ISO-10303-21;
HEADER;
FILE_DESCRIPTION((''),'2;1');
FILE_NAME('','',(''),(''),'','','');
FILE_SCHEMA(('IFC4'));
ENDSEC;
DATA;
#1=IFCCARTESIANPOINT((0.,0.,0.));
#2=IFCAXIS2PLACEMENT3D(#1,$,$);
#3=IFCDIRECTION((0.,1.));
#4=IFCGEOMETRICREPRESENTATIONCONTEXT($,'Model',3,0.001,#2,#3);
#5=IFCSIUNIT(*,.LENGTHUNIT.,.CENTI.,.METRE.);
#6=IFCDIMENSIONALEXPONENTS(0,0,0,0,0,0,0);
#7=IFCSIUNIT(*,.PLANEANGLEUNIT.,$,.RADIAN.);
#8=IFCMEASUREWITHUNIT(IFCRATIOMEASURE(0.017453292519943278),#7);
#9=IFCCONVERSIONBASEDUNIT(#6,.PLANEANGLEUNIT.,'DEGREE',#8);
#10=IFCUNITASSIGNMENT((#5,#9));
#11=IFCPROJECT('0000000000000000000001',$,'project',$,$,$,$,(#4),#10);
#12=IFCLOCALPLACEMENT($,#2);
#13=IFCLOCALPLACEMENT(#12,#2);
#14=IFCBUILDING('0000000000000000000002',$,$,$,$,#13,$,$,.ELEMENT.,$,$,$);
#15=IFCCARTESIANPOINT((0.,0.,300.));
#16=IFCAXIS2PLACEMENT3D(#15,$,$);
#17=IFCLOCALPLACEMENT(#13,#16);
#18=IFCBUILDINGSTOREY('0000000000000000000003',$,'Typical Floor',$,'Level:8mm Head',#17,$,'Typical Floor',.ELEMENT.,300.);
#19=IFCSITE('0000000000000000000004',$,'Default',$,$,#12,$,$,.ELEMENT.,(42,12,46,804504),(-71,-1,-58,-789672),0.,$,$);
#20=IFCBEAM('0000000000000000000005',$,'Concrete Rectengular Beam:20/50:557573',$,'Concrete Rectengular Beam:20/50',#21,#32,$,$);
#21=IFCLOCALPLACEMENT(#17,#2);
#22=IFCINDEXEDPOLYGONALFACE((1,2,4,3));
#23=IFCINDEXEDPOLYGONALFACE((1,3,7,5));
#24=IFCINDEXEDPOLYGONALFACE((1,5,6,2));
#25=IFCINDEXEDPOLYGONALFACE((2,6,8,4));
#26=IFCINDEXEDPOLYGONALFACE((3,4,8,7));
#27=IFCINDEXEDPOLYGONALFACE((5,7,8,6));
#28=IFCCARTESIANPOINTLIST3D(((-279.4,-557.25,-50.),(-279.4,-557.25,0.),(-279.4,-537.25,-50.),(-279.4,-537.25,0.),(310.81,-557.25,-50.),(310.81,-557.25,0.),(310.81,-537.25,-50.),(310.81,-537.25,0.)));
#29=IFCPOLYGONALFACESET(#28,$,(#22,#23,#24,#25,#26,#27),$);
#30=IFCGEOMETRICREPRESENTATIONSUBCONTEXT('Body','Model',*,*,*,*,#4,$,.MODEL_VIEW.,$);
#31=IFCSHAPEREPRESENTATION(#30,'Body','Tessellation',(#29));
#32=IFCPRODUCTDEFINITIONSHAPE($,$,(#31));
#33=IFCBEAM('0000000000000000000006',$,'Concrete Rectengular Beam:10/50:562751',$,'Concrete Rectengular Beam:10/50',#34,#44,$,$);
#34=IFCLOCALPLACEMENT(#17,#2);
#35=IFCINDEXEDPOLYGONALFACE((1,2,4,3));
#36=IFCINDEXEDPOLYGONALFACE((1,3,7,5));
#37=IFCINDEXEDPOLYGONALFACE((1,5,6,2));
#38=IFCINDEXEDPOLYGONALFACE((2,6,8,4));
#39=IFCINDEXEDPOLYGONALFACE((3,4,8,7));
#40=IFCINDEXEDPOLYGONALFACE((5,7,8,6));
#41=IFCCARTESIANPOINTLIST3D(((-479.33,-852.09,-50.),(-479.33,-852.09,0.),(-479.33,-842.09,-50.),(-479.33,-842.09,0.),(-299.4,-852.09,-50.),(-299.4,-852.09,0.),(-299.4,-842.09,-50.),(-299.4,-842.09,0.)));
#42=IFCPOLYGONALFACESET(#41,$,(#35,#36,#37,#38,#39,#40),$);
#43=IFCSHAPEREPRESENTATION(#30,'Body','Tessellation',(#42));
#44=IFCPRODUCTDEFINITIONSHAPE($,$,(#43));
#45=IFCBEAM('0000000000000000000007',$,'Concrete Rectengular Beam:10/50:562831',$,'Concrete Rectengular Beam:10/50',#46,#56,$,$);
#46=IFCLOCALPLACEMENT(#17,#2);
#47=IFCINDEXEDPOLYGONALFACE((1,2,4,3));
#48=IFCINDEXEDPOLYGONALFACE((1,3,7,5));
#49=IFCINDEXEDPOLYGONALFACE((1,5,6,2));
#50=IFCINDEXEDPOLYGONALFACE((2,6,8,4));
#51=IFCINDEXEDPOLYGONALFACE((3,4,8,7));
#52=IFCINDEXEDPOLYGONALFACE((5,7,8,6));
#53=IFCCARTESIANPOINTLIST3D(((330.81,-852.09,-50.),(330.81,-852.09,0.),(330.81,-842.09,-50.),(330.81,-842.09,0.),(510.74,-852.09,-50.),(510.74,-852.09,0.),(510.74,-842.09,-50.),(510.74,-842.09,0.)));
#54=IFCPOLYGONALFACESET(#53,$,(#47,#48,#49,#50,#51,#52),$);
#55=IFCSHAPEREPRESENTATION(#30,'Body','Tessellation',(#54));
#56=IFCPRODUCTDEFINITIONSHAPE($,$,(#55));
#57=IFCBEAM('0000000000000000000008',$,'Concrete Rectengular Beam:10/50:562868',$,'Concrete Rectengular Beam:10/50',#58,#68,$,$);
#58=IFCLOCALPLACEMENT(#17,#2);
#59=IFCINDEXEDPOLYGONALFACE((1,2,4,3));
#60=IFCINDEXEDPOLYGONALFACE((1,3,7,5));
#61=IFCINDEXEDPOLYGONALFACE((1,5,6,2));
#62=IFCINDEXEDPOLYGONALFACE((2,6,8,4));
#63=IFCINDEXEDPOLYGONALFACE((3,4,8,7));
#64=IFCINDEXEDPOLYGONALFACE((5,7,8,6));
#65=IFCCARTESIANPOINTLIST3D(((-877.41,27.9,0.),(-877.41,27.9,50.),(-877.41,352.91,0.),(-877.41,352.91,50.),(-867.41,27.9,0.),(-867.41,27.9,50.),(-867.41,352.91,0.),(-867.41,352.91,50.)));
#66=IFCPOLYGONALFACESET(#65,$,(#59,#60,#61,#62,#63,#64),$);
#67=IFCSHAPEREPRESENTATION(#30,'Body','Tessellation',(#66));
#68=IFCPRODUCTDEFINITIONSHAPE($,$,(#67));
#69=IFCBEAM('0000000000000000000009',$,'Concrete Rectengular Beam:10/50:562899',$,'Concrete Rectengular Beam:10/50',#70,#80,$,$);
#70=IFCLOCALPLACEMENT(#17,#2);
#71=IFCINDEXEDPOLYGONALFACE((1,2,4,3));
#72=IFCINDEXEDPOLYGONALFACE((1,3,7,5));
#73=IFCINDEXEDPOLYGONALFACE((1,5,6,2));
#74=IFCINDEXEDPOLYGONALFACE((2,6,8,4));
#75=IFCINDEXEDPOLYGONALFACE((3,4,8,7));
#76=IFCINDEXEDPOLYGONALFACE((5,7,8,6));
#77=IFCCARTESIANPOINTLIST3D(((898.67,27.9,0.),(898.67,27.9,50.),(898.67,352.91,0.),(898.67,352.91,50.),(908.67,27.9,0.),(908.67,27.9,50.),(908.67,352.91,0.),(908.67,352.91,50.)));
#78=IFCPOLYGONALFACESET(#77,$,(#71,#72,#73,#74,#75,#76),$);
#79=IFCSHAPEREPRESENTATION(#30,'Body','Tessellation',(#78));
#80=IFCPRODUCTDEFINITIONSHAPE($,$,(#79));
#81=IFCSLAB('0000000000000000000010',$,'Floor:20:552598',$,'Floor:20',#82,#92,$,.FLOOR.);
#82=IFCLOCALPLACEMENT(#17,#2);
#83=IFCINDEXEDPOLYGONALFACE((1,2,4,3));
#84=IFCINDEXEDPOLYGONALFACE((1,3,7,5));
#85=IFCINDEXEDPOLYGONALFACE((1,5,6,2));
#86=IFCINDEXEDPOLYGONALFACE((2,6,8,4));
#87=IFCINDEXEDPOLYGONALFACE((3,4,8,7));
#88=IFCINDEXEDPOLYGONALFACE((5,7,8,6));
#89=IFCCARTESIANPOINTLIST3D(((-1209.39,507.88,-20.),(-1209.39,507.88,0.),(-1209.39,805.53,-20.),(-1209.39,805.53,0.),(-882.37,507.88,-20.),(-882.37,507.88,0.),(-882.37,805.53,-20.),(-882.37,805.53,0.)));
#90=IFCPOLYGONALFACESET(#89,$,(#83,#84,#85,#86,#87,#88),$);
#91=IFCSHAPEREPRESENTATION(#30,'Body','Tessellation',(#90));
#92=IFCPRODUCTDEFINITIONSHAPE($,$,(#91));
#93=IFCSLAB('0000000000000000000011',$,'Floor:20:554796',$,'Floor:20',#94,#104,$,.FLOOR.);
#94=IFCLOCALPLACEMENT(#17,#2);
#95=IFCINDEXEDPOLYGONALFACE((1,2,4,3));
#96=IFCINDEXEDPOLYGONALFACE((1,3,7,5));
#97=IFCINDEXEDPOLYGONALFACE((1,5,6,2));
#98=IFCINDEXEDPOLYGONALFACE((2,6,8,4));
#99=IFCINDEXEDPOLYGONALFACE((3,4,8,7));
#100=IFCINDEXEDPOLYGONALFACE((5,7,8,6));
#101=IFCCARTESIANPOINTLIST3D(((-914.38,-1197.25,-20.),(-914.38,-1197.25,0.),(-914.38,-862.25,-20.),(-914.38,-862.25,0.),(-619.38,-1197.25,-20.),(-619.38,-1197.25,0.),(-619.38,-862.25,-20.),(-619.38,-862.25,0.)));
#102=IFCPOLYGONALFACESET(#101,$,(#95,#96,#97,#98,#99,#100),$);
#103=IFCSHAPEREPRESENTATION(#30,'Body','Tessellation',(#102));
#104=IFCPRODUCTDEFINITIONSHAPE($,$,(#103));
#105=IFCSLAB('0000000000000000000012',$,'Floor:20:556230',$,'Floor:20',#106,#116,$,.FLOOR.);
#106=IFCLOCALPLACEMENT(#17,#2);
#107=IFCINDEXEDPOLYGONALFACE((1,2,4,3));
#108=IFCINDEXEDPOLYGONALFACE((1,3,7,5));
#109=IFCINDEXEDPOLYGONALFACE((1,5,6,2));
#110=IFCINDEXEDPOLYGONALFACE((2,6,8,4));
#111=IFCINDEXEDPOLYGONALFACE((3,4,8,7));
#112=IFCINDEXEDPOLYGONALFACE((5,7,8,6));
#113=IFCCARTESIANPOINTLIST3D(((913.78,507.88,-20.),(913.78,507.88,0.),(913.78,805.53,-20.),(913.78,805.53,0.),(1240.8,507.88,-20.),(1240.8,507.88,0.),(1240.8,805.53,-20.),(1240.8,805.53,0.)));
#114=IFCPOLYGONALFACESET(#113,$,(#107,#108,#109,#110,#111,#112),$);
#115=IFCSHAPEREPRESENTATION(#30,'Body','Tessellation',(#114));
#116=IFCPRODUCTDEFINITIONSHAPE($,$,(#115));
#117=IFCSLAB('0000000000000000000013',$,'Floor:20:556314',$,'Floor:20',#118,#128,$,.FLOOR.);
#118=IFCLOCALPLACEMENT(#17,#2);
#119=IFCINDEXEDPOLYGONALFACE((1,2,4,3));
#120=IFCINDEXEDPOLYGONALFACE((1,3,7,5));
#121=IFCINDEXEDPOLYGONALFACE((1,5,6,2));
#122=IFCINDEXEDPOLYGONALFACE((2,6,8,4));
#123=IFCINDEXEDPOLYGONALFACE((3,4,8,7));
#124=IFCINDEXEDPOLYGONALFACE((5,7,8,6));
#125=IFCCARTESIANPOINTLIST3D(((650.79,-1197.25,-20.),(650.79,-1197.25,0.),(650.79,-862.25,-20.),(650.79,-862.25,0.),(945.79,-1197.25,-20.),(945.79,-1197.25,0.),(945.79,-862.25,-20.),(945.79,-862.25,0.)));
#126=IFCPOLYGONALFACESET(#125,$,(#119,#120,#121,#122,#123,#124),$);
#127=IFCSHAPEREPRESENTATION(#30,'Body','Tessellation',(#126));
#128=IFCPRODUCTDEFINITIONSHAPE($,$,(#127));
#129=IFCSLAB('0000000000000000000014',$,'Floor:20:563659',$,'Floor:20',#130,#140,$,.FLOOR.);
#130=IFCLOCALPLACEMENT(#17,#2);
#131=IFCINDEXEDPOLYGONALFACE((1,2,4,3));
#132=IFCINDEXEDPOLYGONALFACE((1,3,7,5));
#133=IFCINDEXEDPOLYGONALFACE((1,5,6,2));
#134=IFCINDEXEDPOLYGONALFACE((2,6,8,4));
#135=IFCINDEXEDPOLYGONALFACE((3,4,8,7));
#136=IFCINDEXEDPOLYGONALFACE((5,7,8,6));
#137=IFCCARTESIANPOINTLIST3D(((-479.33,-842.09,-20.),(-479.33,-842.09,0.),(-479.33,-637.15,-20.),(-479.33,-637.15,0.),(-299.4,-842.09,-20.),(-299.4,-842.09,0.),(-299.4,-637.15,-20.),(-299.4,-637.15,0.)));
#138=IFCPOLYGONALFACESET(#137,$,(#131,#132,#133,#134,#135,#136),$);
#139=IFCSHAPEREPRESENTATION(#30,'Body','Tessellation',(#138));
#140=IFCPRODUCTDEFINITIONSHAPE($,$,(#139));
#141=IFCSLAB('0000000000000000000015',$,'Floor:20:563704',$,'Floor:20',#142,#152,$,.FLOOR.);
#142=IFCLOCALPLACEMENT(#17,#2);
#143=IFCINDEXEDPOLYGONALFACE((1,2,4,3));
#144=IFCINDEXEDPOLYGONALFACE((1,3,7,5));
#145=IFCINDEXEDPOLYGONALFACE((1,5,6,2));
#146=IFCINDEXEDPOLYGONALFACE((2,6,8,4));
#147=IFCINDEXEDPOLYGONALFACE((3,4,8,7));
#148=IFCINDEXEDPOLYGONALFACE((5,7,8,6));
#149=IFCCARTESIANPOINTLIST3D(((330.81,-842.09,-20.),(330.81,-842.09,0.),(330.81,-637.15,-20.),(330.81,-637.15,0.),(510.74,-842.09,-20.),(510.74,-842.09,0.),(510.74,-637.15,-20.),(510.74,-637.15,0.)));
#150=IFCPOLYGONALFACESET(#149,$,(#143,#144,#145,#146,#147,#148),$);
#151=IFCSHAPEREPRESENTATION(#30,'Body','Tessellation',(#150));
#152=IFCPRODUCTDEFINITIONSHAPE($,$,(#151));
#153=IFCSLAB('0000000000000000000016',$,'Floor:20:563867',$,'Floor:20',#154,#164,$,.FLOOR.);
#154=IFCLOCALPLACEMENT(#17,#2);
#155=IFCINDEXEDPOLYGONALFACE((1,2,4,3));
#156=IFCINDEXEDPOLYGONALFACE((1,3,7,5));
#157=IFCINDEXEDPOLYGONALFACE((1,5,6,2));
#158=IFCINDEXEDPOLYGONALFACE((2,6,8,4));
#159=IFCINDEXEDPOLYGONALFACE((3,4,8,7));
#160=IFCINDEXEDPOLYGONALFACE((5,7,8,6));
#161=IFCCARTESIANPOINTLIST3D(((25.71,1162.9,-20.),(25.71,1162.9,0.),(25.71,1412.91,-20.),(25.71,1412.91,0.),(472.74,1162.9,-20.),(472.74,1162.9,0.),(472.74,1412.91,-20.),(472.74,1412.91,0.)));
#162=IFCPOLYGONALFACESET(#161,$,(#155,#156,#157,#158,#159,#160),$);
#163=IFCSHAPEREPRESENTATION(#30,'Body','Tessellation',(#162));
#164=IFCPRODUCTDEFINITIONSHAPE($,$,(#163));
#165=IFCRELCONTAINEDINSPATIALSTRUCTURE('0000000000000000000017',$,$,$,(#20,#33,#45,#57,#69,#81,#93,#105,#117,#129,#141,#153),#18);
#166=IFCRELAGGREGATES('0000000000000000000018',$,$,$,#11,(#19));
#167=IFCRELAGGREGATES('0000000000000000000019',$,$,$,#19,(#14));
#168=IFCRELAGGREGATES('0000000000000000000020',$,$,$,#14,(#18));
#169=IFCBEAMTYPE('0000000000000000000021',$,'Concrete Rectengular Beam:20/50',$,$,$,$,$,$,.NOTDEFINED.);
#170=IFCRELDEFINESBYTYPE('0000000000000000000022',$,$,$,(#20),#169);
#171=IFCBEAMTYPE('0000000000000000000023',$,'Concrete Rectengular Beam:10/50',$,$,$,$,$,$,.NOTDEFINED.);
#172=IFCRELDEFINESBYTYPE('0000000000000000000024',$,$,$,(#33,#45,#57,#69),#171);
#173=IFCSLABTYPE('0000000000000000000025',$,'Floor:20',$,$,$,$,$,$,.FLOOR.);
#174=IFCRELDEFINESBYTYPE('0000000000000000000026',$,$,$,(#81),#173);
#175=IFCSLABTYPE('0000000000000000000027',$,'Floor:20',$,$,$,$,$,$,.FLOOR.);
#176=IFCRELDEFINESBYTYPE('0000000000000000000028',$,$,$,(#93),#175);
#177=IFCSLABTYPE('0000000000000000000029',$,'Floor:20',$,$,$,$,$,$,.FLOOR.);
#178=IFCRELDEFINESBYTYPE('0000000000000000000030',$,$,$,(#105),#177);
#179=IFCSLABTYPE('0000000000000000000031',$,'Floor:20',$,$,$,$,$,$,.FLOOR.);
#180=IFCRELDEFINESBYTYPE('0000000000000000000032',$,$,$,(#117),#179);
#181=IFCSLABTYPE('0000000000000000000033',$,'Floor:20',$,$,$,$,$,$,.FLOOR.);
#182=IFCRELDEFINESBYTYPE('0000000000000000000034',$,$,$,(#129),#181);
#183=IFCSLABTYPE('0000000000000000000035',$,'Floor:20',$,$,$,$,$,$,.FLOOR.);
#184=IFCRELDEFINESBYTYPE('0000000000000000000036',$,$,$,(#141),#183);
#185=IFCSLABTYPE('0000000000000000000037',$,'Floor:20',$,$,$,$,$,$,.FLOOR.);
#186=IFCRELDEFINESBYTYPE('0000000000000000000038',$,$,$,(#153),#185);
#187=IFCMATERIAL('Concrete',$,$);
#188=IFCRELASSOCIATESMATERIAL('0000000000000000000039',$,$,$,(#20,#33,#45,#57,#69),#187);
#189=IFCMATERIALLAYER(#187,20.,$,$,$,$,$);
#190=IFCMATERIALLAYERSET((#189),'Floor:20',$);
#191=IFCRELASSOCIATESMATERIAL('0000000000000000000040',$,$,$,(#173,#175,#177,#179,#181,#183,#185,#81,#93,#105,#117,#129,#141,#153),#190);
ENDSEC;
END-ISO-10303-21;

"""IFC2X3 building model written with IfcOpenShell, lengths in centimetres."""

from ifc_helpers import new_model, entity, si_unit, converted_unit, direction, frame, frame_2d, origin, origin_2d_with_axis, place, context, subcontext, project, spatial, rectangle, extrude, material, layer, layer_set, layer_usage, type_object, element, save


model = new_model("IFC2X3")

# Units and contexts
model_context = context("Model", 3, precision=0.001, world=origin(), true_north=direction((0.0, 1.0)))
body_context = subcontext(model_context, "Body", "Model", "MODEL_VIEW")
ifc_project = project(units=[si_unit("LENGTHUNIT", "METRE", prefix="CENTI"), converted_unit("PLANEANGLEUNIT", "DEGREE", entity("IfcRatioMeasure", 0.017453292519943278), si_unit("PLANEANGLEUNIT", "RADIAN"), dimensions=[0, 0, 0, 0, 0, 0, 0])], contexts=[model_context])

# Site, building, storey
site_placement = place(None, origin())
site = spatial("IfcSite", under=ifc_project, at=site_placement, Name="Default", CompositionType="ELEMENT", RefLatitude=(42, 12, 46, 804504), RefLongitude=(-71, -1, -58, -789672), RefElevation=0.0)
building_placement = place(site_placement, origin())
building = spatial("IfcBuilding", under=site, at=building_placement, CompositionType="ELEMENT")
storey_placement = place(building_placement, frame((0.0, 0.0, 300.0)))
storey = spatial("IfcBuildingStorey", under=building, at=storey_placement, Name="Typical Floor", ObjectType="Level:8mm Head", LongName="Typical Floor", CompositionType="ELEMENT", Elevation=300.0)

# Beams
ifc_material = material(Name="Concrete")
beam_type_1 = type_object("IfcBeamType", Name="Concrete Rectengular Beam:20/50", PredefinedType="NOTDEFINED")
beam_1_placement = place(storey_placement, frame((-289.4, -547.25, 0.0)))
element("IfcBeam", 1, at=beam_1_placement, inside=storey, type_object=beam_type_1, material=ifc_material, Name="Concrete Rectengular Beam:20/50:557573", ObjectType="Concrete Rectengular Beam:20/50", context=body_context, shape_type="SweptSolid", body=[
    extrude(rectangle(XDim=50.0, YDim=20.0, at=frame_2d((0.0, 0.0), x_axis=(1.0, 0.0))), frame((10.0, 0.0, -25.0), z_axis=(1.0, 0.0, 0.0), x_axis=(0.0, 0.0, -1.0)), (0.0, 0.0, 1.0), 590.21),
])
beam_type_2 = type_object("IfcBeamType", Name="Concrete Rectengular Beam:10/50", PredefinedType="NOTDEFINED")
beam_2_placement = place(storey_placement, frame((-489.33, -847.09, 0.0)))
element("IfcBeam", 2, at=beam_2_placement, inside=storey, type_object=beam_type_2, material=ifc_material, Name="Concrete Rectengular Beam:10/50:562751", ObjectType="Concrete Rectengular Beam:10/50", context=body_context, shape_type="SweptSolid", body=[
    extrude(rectangle(XDim=50.0, YDim=10.0, at=frame_2d((0.0, 0.0), x_axis=(1.0, 0.0))), frame((10.0, 0.0, -25.0), z_axis=(1.0, 0.0, 0.0), x_axis=(0.0, 0.0, -1.0)), (0.0, 0.0, 1.0), 179.93),
])
beam_3_placement = place(storey_placement, frame((320.81, -847.09, 0.0)))
element("IfcBeam", 3, at=beam_3_placement, inside=storey, type_object=beam_type_2, material=ifc_material, Name="Concrete Rectengular Beam:10/50:562831", ObjectType="Concrete Rectengular Beam:10/50", context=body_context, shape_type="SweptSolid", body=[
    extrude(rectangle(XDim=50.0, YDim=10.0, at=frame_2d((0.0, 0.0), x_axis=(1.0, 0.0))), frame((10.0, 0.0, -25.0), z_axis=(1.0, 0.0, 0.0), x_axis=(0.0, 0.0, -1.0)), (0.0, 0.0, 1.0), 179.93),
])
for number, where, z_axis, x_axis, name in (
    (4, (-872.41, 352.91, 0.0), (0.0, 0.0, 1.0), (0.0, -1.0, 0.0), "Concrete Rectengular Beam:10/50:562868"),
    (5, (903.67, 352.91, 0.0), (0.0, 0.0, 1.0), (0.0, -1.0, 0.0), "Concrete Rectengular Beam:10/50:562899"),
):
    element("IfcBeam", number, at=place(storey_placement, frame(where, z_axis=z_axis, x_axis=x_axis)), inside=storey, type_object=beam_type_2, material=ifc_material, Name=name, ObjectType="Concrete Rectengular Beam:10/50", context=body_context, shape_type="SweptSolid", body=[
        extrude(rectangle(XDim=50.0, YDim=10.0, at=origin_2d_with_axis()), frame((0.0, 0.0, 25.0), z_axis=(1.0, 0.0, 0.0), x_axis=(0.0, 0.0, -1.0)), (0.0, 0.0, 1.0), 325.01),
    ])

# Slabs
ifc_layer = layer(ifc_material, 20.0)
ifc_layer_set = layer_set([ifc_layer], Name="Floor:20")
ifc_layer_usage_1 = layer_usage(ifc_layer_set, "AXIS3", "POSITIVE", 0.0)
slab_type_1 = type_object("IfcSlabType", Name="Floor:20", PredefinedType="FLOOR", material=ifc_layer_set)
slab_1_placement = place(storey_placement, origin())
element("IfcSlab", 6, at=slab_1_placement, inside=storey, type_object=slab_type_1, material=ifc_layer_usage_1, Name="Floor:20:552598", ObjectType="Floor:20", PredefinedType="FLOOR", context=body_context, shape_type="SweptSolid", body=[
    extrude(rectangle(XDim=297.65, YDim=327.02, at=frame_2d((0.0, 0.0), x_axis=(1.0, 0.0))), frame((-1045.88, 656.7, 0.0), z_axis=(0.0, 0.0, -1.0), x_axis=(0.0, 1.0, 0.0)), (0.0, 0.0, 1.0), 20.0),
])
ifc_layer_usage_2 = layer_usage(ifc_layer_set, "AXIS3", "POSITIVE", 0.0)
slab_type_2 = type_object("IfcSlabType", Name="Floor:20", PredefinedType="FLOOR", material=ifc_layer_set)
slab_2_placement = place(storey_placement, origin())
element("IfcSlab", 7, at=slab_2_placement, inside=storey, type_object=slab_type_2, material=ifc_layer_usage_2, Name="Floor:20:554796", ObjectType="Floor:20", PredefinedType="FLOOR", context=body_context, shape_type="SweptSolid", body=[
    extrude(rectangle(XDim=334.99, YDim=295.0, at=origin_2d_with_axis()), frame((-766.88, -1029.75, 0.0), z_axis=(0.0, 0.0, -1.0), x_axis=(0.0, 1.0, 0.0)), (0.0, 0.0, 1.0), 20.0),
])
ifc_layer_usage_3 = layer_usage(ifc_layer_set, "AXIS3", "POSITIVE", 0.0)
slab_type_3 = type_object("IfcSlabType", Name="Floor:20", PredefinedType="FLOOR", material=ifc_layer_set)
slab_3_placement = place(storey_placement, origin())
element("IfcSlab", 8, at=slab_3_placement, inside=storey, type_object=slab_type_3, material=ifc_layer_usage_3, Name="Floor:20:556230", ObjectType="Floor:20", PredefinedType="FLOOR", context=body_context, shape_type="SweptSolid", body=[
    extrude(rectangle(XDim=297.65, YDim=327.02, at=frame_2d((0.0, 0.0), x_axis=(1.0, 0.0))), frame((1077.29, 656.7, 0.0), z_axis=(0.0, 0.0, -1.0), x_axis=(0.0, 1.0, 0.0)), (0.0, 0.0, 1.0), 20.0),
])
ifc_layer_usage_4 = layer_usage(ifc_layer_set, "AXIS3", "POSITIVE", 0.0)
slab_type_4 = type_object("IfcSlabType", Name="Floor:20", PredefinedType="FLOOR", material=ifc_layer_set)
slab_4_placement = place(storey_placement, origin())
element("IfcSlab", 9, at=slab_4_placement, inside=storey, type_object=slab_type_4, material=ifc_layer_usage_4, Name="Floor:20:556314", ObjectType="Floor:20", PredefinedType="FLOOR", context=body_context, shape_type="SweptSolid", body=[
    extrude(rectangle(XDim=334.99, YDim=295.0, at=origin_2d_with_axis()), frame((798.29, -1029.75, 0.0), z_axis=(0.0, 0.0, -1.0), x_axis=(0.0, 1.0, 0.0)), (0.0, 0.0, 1.0), 20.0),
])
ifc_layer_usage_5 = layer_usage(ifc_layer_set, "AXIS3", "POSITIVE", 0.0)
slab_type_5 = type_object("IfcSlabType", Name="Floor:20", PredefinedType="FLOOR", material=ifc_layer_set)
slab_5_placement = place(storey_placement, origin())
element("IfcSlab", 10, at=slab_5_placement, inside=storey, type_object=slab_type_5, material=ifc_layer_usage_5, Name="Floor:20:563659", ObjectType="Floor:20", PredefinedType="FLOOR", context=body_context, shape_type="SweptSolid", body=[
    extrude(rectangle(XDim=204.95, YDim=179.93, at=frame_2d((0.0, 0.0), x_axis=(1.0, 0.0))), frame((-389.36, -739.62, 0.0), z_axis=(0.0, 0.0, -1.0), x_axis=(0.0, 1.0, 0.0)), (0.0, 0.0, 1.0), 20.0),
])
ifc_layer_usage_6 = layer_usage(ifc_layer_set, "AXIS3", "POSITIVE", 0.0)
slab_type_6 = type_object("IfcSlabType", Name="Floor:20", PredefinedType="FLOOR", material=ifc_layer_set)
slab_6_placement = place(storey_placement, origin())
element("IfcSlab", 11, at=slab_6_placement, inside=storey, type_object=slab_type_6, material=ifc_layer_usage_6, Name="Floor:20:563704", ObjectType="Floor:20", PredefinedType="FLOOR", context=body_context, shape_type="SweptSolid", body=[
    extrude(rectangle(XDim=204.95, YDim=179.93, at=frame_2d((0.0, 0.0), x_axis=(1.0, 0.0))), frame((420.77, -739.62, 0.0), z_axis=(0.0, 0.0, -1.0), x_axis=(0.0, 1.0, 0.0)), (0.0, 0.0, 1.0), 20.0),
])
ifc_layer_usage_7 = layer_usage(ifc_layer_set, "AXIS3", "POSITIVE", 0.0)
slab_type_7 = type_object("IfcSlabType", Name="Floor:20", PredefinedType="FLOOR", material=ifc_layer_set)
slab_7_placement = place(storey_placement, origin())
element("IfcSlab", 12, at=slab_7_placement, inside=storey, type_object=slab_type_7, material=ifc_layer_usage_7, Name="Floor:20:563867", ObjectType="Floor:20", PredefinedType="FLOOR", context=body_context, shape_type="SweptSolid", body=[
    extrude(rectangle(XDim=250.01, YDim=447.04, at=frame_2d((0.0, 0.0), x_axis=(1.0, 0.0))), frame((249.22, 1287.91, 0.0), z_axis=(0.0, 0.0, -1.0), x_axis=(0.0, 1.0, 0.0)), (0.0, 0.0, 1.0), 20.0),
])

save(model, "model.ifc")
